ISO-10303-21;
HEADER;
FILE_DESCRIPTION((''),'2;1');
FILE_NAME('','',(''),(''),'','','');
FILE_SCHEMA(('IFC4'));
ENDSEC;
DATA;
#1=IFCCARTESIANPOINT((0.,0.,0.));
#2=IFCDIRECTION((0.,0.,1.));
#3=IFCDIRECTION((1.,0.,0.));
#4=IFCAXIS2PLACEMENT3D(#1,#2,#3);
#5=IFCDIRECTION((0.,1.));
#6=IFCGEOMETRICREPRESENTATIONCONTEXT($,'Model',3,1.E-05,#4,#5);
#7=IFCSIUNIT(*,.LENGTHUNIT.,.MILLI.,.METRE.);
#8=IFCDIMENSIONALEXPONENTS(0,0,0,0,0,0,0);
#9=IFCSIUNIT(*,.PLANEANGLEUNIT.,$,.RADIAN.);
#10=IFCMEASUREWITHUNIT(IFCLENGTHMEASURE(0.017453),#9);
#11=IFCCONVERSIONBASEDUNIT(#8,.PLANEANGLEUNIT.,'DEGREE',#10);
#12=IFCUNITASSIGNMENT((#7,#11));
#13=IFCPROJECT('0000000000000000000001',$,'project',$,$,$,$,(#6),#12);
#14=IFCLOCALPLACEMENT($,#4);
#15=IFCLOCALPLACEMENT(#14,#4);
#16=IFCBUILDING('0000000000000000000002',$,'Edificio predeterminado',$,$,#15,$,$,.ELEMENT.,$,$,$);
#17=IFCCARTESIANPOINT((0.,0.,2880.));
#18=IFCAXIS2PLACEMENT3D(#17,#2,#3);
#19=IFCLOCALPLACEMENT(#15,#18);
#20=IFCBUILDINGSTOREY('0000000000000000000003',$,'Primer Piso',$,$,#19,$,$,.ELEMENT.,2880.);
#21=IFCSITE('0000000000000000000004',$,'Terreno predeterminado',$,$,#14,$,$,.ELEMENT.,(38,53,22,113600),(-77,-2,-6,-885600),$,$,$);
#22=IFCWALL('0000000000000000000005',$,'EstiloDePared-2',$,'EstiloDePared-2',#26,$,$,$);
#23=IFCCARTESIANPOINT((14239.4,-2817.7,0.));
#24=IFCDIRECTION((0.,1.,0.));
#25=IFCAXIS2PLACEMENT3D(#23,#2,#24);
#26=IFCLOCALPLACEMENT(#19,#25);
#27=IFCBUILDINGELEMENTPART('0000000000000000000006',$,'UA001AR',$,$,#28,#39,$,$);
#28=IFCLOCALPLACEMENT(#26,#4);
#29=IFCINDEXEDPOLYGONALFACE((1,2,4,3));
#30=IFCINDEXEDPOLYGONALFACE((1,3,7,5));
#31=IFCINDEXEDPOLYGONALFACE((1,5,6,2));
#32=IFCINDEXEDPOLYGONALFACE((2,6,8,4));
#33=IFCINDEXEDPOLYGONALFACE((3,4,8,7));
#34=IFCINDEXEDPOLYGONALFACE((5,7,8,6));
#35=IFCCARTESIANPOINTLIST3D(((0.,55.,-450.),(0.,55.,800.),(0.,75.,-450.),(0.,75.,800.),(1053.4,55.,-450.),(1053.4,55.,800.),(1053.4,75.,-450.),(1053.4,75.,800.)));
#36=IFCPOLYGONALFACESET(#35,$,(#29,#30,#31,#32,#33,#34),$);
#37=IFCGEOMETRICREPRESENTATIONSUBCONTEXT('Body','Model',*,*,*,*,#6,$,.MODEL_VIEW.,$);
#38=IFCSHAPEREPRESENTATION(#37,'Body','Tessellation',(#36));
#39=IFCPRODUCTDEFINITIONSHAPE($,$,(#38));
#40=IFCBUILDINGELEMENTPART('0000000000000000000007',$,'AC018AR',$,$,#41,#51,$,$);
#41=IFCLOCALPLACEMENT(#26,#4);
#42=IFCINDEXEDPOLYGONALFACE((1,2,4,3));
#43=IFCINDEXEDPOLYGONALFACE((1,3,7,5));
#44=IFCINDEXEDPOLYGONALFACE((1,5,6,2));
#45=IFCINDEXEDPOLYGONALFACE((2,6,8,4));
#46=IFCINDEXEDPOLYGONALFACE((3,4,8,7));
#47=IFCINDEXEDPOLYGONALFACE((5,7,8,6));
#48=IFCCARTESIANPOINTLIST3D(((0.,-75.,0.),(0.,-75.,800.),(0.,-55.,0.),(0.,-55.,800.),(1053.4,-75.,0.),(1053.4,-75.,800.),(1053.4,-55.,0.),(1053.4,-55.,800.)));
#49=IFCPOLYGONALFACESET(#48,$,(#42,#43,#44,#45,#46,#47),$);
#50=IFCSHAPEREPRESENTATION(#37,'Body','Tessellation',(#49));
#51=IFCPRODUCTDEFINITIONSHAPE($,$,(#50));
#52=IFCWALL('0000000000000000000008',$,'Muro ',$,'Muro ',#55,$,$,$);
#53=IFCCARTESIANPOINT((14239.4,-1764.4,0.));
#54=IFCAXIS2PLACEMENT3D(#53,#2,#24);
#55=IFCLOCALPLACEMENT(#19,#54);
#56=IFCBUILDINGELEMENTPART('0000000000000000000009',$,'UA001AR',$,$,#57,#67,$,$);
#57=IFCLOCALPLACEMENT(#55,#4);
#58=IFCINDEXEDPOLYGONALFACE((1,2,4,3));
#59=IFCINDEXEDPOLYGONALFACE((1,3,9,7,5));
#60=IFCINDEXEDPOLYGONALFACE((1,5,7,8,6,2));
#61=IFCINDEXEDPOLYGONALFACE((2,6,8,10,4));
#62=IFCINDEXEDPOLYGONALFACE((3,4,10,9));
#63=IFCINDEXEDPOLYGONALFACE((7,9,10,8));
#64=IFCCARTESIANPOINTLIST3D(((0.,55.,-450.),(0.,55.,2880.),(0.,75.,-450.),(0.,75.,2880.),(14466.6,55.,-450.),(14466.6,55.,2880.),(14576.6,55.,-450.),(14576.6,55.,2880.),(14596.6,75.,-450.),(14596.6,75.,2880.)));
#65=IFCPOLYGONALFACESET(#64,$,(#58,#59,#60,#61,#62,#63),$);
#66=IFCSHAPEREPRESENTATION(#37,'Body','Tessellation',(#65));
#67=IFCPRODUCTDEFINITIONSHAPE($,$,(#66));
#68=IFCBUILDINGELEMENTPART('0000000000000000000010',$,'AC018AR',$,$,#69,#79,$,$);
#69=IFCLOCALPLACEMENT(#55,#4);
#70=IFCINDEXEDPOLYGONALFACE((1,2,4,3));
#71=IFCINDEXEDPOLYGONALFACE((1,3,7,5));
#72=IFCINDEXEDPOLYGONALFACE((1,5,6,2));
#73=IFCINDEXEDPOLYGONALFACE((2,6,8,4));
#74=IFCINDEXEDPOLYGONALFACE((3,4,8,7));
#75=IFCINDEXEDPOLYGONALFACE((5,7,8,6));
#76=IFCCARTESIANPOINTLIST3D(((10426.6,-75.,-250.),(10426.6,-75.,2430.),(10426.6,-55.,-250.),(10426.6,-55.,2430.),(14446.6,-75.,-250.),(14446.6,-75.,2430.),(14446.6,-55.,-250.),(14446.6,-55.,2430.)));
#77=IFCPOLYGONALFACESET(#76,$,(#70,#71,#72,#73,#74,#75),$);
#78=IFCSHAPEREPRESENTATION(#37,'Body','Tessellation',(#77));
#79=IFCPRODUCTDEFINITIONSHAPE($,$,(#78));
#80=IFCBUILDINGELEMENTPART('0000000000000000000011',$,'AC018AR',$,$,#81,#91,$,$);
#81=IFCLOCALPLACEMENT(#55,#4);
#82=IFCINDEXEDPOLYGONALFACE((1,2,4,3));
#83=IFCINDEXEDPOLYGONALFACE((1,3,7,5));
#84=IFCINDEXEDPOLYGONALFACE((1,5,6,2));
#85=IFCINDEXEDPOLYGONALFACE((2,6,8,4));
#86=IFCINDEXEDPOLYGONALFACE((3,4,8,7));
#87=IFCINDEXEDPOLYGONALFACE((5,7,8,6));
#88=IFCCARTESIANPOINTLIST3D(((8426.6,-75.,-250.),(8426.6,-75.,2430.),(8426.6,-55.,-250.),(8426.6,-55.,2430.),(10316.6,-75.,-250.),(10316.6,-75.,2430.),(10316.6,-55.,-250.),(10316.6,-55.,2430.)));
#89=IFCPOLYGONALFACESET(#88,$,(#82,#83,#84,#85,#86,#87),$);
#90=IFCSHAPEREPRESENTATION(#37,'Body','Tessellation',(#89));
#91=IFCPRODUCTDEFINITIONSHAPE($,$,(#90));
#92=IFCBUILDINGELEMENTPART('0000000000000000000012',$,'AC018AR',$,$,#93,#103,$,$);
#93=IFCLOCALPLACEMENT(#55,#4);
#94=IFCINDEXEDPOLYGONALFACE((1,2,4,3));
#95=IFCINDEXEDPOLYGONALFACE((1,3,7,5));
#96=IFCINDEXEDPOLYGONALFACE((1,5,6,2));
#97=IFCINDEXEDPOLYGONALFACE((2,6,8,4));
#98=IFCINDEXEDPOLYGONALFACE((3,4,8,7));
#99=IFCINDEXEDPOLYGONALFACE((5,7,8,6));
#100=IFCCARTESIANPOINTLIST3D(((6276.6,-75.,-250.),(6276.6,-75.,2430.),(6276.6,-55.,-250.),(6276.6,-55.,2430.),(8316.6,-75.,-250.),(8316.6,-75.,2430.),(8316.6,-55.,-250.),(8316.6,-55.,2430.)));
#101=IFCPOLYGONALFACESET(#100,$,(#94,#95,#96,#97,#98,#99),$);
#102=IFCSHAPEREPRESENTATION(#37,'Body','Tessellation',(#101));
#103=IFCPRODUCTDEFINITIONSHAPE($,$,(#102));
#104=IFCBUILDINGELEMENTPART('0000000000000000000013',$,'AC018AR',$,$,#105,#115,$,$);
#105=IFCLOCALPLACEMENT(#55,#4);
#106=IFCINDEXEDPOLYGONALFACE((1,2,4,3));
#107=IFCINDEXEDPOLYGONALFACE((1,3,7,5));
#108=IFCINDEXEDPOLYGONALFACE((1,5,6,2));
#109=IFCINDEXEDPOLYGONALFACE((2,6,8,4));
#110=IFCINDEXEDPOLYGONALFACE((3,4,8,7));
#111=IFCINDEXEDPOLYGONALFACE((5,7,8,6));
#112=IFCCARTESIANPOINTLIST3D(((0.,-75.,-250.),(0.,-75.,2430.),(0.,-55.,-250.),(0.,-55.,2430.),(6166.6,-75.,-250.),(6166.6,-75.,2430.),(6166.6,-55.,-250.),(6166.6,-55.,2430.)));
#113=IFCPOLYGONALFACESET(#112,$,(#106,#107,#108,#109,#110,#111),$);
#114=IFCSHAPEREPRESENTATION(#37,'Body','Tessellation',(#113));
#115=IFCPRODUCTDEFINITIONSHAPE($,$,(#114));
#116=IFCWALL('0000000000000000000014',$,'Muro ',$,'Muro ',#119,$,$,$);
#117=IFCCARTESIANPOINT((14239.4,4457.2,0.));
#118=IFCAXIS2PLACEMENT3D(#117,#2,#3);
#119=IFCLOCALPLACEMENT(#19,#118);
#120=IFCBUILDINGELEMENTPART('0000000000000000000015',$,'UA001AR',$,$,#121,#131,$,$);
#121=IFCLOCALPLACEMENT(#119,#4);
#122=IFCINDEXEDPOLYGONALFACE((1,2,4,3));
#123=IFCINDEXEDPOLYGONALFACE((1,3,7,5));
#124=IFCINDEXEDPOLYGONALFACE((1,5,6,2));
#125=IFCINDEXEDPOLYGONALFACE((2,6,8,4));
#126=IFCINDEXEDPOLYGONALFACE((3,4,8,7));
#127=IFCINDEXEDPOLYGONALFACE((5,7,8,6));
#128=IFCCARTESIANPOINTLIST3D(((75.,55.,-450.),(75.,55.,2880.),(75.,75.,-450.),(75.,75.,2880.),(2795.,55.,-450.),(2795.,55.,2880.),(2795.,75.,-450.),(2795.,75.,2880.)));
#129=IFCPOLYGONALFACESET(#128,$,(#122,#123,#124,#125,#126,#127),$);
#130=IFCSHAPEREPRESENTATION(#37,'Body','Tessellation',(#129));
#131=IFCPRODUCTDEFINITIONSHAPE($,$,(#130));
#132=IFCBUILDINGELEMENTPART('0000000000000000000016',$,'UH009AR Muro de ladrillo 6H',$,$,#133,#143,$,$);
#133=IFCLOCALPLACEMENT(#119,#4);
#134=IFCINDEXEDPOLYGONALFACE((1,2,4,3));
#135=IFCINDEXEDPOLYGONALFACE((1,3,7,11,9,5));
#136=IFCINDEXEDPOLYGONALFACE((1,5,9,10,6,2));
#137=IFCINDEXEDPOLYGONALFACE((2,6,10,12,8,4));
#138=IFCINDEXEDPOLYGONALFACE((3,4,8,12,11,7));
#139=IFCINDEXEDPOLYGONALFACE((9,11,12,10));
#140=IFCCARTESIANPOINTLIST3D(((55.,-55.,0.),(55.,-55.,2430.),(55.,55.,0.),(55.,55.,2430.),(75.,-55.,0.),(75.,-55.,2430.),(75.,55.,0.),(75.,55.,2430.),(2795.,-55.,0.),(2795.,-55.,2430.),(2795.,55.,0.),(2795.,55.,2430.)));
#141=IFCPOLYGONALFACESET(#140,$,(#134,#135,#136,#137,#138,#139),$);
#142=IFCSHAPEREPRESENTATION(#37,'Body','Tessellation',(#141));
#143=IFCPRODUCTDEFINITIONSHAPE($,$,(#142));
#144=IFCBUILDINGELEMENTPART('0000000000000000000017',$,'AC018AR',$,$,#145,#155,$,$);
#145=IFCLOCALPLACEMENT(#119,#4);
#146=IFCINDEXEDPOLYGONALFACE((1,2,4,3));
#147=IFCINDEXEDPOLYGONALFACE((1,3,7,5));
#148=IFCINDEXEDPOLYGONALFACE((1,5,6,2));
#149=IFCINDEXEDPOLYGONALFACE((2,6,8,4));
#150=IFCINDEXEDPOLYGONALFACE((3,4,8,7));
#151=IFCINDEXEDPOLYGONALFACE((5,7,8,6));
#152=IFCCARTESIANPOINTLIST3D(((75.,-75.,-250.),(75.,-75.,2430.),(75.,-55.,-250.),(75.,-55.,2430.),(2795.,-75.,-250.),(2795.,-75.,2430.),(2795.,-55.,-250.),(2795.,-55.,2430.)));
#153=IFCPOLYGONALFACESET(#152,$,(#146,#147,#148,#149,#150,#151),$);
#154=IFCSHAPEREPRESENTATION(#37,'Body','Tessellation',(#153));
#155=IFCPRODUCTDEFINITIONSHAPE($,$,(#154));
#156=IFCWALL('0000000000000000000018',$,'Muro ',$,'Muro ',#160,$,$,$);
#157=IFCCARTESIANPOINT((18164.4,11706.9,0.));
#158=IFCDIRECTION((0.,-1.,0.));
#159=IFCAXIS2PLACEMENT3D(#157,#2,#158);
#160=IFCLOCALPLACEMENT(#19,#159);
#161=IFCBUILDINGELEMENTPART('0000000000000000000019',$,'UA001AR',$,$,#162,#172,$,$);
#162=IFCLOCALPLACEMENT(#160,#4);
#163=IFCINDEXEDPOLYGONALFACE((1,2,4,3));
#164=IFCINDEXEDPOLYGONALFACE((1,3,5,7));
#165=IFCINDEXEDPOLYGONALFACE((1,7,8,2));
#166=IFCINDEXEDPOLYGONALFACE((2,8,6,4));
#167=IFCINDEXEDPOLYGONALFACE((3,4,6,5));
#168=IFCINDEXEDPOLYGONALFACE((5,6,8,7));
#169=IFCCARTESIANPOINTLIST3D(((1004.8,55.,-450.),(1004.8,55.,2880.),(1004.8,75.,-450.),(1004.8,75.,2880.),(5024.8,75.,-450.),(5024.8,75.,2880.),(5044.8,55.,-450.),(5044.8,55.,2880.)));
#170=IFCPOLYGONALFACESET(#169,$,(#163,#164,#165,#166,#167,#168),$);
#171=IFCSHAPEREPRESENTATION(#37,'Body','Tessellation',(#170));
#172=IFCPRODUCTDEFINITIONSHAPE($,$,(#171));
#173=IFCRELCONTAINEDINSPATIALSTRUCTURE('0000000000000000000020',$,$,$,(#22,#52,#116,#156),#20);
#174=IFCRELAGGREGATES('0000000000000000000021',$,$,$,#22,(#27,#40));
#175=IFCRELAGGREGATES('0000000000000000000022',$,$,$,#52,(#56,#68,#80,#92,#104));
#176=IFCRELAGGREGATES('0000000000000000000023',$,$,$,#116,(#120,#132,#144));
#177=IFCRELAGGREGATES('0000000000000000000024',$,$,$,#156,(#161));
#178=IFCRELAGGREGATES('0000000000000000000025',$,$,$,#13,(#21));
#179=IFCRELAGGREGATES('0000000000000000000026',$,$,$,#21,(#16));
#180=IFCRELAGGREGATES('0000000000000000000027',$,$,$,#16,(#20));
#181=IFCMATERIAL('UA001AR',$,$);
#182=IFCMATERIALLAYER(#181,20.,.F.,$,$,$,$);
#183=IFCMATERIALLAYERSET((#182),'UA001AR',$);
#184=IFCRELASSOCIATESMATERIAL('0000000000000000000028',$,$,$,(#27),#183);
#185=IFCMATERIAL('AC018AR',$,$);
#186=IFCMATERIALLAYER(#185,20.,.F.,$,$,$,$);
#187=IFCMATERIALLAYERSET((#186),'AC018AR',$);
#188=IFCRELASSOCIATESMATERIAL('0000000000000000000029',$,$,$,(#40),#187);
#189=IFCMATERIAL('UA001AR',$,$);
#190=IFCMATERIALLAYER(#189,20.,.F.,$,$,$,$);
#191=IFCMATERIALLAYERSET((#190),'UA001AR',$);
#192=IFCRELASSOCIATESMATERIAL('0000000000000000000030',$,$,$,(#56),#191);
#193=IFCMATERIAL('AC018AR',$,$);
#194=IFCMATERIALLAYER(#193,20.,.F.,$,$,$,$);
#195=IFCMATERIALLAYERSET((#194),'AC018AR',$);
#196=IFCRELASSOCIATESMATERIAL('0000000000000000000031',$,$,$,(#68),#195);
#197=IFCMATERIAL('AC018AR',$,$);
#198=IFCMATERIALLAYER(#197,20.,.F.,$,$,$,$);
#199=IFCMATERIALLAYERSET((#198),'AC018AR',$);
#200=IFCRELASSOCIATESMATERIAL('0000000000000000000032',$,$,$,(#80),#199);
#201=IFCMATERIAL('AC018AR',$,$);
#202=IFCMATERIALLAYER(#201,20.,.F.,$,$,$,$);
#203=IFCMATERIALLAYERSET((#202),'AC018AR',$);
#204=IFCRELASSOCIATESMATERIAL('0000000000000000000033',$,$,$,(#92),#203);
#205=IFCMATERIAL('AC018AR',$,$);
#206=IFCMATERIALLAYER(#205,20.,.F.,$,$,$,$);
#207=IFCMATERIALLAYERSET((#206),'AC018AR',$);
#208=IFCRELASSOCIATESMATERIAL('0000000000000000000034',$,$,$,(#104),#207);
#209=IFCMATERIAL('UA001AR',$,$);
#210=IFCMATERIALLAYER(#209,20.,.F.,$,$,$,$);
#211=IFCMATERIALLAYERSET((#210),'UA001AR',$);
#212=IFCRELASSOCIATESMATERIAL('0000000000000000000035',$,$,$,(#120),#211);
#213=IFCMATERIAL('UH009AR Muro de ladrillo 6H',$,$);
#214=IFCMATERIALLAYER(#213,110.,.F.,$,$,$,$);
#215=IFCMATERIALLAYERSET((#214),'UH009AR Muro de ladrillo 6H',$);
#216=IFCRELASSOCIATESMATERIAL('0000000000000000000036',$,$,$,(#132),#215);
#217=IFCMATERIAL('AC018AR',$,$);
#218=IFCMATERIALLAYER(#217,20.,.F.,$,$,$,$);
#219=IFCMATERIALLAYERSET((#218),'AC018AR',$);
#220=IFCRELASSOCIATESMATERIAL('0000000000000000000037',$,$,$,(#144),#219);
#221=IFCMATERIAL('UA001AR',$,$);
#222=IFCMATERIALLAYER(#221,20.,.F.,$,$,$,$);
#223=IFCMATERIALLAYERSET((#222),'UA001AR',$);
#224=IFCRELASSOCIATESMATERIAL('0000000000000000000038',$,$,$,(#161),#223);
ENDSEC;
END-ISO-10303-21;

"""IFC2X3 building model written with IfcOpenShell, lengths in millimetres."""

from ifc_helpers import new_model, entity, si_unit, converted_unit, direction, frame, origin_with_axes, place, context, subcontext, project, spatial, polyline, outline, extrude, material, layer, layer_set, layer_usage, element, aggregate, save


model = new_model("IFC2X3")

# Units and contexts
model_context = context("Model", 3, precision=1e-05, world=origin_with_axes(), true_north=direction((0.0, 1.0)))
body_context = subcontext(model_context, "Body", "Model", "MODEL_VIEW")
ifc_project = project(units=[si_unit("LENGTHUNIT", "METRE", prefix="MILLI"), converted_unit("PLANEANGLEUNIT", "DEGREE", entity("IfcLengthMeasure", 0.017453), si_unit("PLANEANGLEUNIT", "RADIAN"), dimensions=[0, 0, 0, 0, 0, 0, 0])], contexts=[model_context])

# Site, building, storey
site_placement = place(None, origin_with_axes())
site = spatial("IfcSite", under=ifc_project, at=site_placement, Name="Terreno predeterminado", CompositionType="ELEMENT", RefLatitude=(38, 53, 22, 113600), RefLongitude=(-77, -2, -6, -885600))
building_placement = place(site_placement, origin_with_axes())
building = spatial("IfcBuilding", under=site, at=building_placement, Name="Edificio predeterminado", CompositionType="ELEMENT")
storey_placement = place(building_placement, frame((0.0, 0.0, 2880.0), z_axis=(0.0, 0.0, 1.0), x_axis=(1.0, 0.0, 0.0)))
storey = spatial("IfcBuildingStorey", under=building, at=storey_placement, Name="Primer Piso", CompositionType="ELEMENT", Elevation=2880.0)

# Walls, building element parts
wall_1_placement = place(storey_placement, frame((14239.4, -2817.7, 0.0), z_axis=(0.0, 0.0, 1.0), x_axis=(0.0, 1.0, 0.0)))
wall_1 = element("IfcWall", 1, at=wall_1_placement, inside=storey, Name="EstiloDePared-2", ObjectType="EstiloDePared-2")
ifc_material_1 = material(Name="UA001AR")
ifc_layer_1 = layer(ifc_material_1, 20.0, ventilated=False)
ifc_layer_set_1 = layer_set([ifc_layer_1], Name="UA001AR")
ifc_layer_usage_1 = layer_usage(ifc_layer_set_1, "AXIS2", "NEGATIVE", -75.0)
building_element_part_1_placement = place(wall_1_placement, origin_with_axes())
building_element_part_1 = element("IfcBuildingElementPart", 2, at=building_element_part_1_placement, material=ifc_layer_usage_1, Name="UA001AR", context=body_context, shape_type="SweptSolid", body=[
    extrude(outline(polyline([(1053.4, 75.0), (1053.4, 55.0), (0.0, 55.0), (0.0, 75.0), (1053.4, 75.0)])), frame((0.0, 0.0, -450.0), z_axis=(0.0, 0.0, 1.0), x_axis=(1.0, 0.0, 0.0)), (0.0, 0.0, 1.0), 1250.0),
])
ifc_material_2 = material(Name="AC018AR")
ifc_layer_2 = layer(ifc_material_2, 20.0, ventilated=False)
ifc_layer_set_2 = layer_set([ifc_layer_2], Name="AC018AR")
ifc_layer_usage_2 = layer_usage(ifc_layer_set_2, "AXIS2", "NEGATIVE", 55.0)
building_element_part_2_placement = place(wall_1_placement, origin_with_axes())
building_element_part_2 = element("IfcBuildingElementPart", 3, at=building_element_part_2_placement, material=ifc_layer_usage_2, Name="AC018AR", context=body_context, shape_type="SweptSolid", body=[
    extrude(outline(polyline([(1053.4, -55.0), (1053.4, -75.0), (0.0, -75.0), (0.0, -55.0), (1053.4, -55.0)])), origin_with_axes(), (0.0, 0.0, 1.0), 800.0),
])
aggregate(wall_1, [building_element_part_1, building_element_part_2])
wall_2_placement = place(storey_placement, frame((14239.4, -1764.4, 0.0), z_axis=(0.0, 0.0, 1.0), x_axis=(0.0, 1.0, 0.0)))
wall_2 = element("IfcWall", 4, at=wall_2_placement, inside=storey, Name="Muro ", ObjectType="Muro ")
ifc_material_3 = material(Name="UA001AR")
ifc_layer_3 = layer(ifc_material_3, 20.0, ventilated=False)
ifc_layer_set_3 = layer_set([ifc_layer_3], Name="UA001AR")
ifc_layer_usage_3 = layer_usage(ifc_layer_set_3, "AXIS2", "NEGATIVE", -75.0)
building_element_part_3_placement = place(wall_2_placement, origin_with_axes())
building_element_part_3 = element("IfcBuildingElementPart", 5, at=building_element_part_3_placement, material=ifc_layer_usage_3, Name="UA001AR", context=body_context, shape_type="SweptSolid", body=[
    extrude(outline(polyline([(14596.6, 75.0), (14576.6, 55.0), (14466.6, 55.0), (0.0, 55.0), (0.0, 75.0), (14596.6, 75.0)])), frame((0.0, 0.0, -450.0), z_axis=(0.0, 0.0, 1.0), x_axis=(1.0, 0.0, 0.0)), (0.0, 0.0, 1.0), 3330.0),
])
ifc_material_4 = material(Name="AC018AR")
ifc_layer_4 = layer(ifc_material_4, 20.0, ventilated=False)
ifc_layer_set_4 = layer_set([ifc_layer_4], Name="AC018AR")
ifc_layer_usage_4 = layer_usage(ifc_layer_set_4, "AXIS2", "NEGATIVE", 55.0)
building_element_part_4_placement = place(wall_2_placement, origin_with_axes())
building_element_part_4 = element("IfcBuildingElementPart", 6, at=building_element_part_4_placement, material=ifc_layer_usage_4, Name="AC018AR", context=body_context, shape_type="SweptSolid", body=[
    extrude(outline(polyline([(14446.6, -55.0), (14446.6, -75.0), (10426.6, -75.0), (10426.6, -55.0), (14446.6, -55.0)])), frame((0.0, 0.0, -250.0), z_axis=(0.0, 0.0, 1.0), x_axis=(1.0, 0.0, 0.0)), (0.0, 0.0, 1.0), 2680.0),
])
ifc_material_5 = material(Name="AC018AR")
ifc_layer_5 = layer(ifc_material_5, 20.0, ventilated=False)
ifc_layer_set_5 = layer_set([ifc_layer_5], Name="AC018AR")
ifc_layer_usage_5 = layer_usage(ifc_layer_set_5, "AXIS2", "NEGATIVE", 55.0)
building_element_part_5_placement = place(wall_2_placement, origin_with_axes())
building_element_part_5 = element("IfcBuildingElementPart", 7, at=building_element_part_5_placement, material=ifc_layer_usage_5, Name="AC018AR", context=body_context, shape_type="SweptSolid", body=[
    extrude(outline(polyline([(10316.6, -55.0), (10316.6, -75.0), (8426.6, -75.0), (8426.6, -55.0), (10316.6, -55.0)])), frame((0.0, 0.0, -250.0), z_axis=(0.0, 0.0, 1.0), x_axis=(1.0, 0.0, 0.0)), (0.0, 0.0, 1.0), 2680.0),
])
ifc_material_6 = material(Name="AC018AR")
ifc_layer_6 = layer(ifc_material_6, 20.0, ventilated=False)
ifc_layer_set_6 = layer_set([ifc_layer_6], Name="AC018AR")
ifc_layer_usage_6 = layer_usage(ifc_layer_set_6, "AXIS2", "NEGATIVE", 55.0)
building_element_part_6_placement = place(wall_2_placement, origin_with_axes())
building_element_part_6 = element("IfcBuildingElementPart", 8, at=building_element_part_6_placement, material=ifc_layer_usage_6, Name="AC018AR", context=body_context, shape_type="SweptSolid", body=[
    extrude(outline(polyline([(8316.6, -55.0), (8316.6, -75.0), (6276.6, -75.0), (6276.6, -55.0), (8316.6, -55.0)])), frame((0.0, 0.0, -250.0), z_axis=(0.0, 0.0, 1.0), x_axis=(1.0, 0.0, 0.0)), (0.0, 0.0, 1.0), 2680.0),
])
ifc_material_7 = material(Name="AC018AR")
ifc_layer_7 = layer(ifc_material_7, 20.0, ventilated=False)
ifc_layer_set_7 = layer_set([ifc_layer_7], Name="AC018AR")
ifc_layer_usage_7 = layer_usage(ifc_layer_set_7, "AXIS2", "NEGATIVE", 55.0)
building_element_part_7_placement = place(wall_2_placement, origin_with_axes())
building_element_part_7 = element("IfcBuildingElementPart", 9, at=building_element_part_7_placement, material=ifc_layer_usage_7, Name="AC018AR", context=body_context, shape_type="SweptSolid", body=[
    extrude(outline(polyline([(6166.6, -55.0), (6166.6, -75.0), (0.0, -75.0), (0.0, -55.0), (6166.6, -55.0)])), frame((0.0, 0.0, -250.0), z_axis=(0.0, 0.0, 1.0), x_axis=(1.0, 0.0, 0.0)), (0.0, 0.0, 1.0), 2680.0),
])
aggregate(wall_2, [building_element_part_3, building_element_part_4, building_element_part_5, building_element_part_6, building_element_part_7])
wall_3_placement = place(storey_placement, frame((14239.4, 4457.2, 0.0), z_axis=(0.0, 0.0, 1.0), x_axis=(1.0, 0.0, 0.0)))
wall_3 = element("IfcWall", 10, at=wall_3_placement, inside=storey, Name="Muro ", ObjectType="Muro ")
ifc_material_8 = material(Name="UA001AR")
ifc_layer_8 = layer(ifc_material_8, 20.0, ventilated=False)
ifc_layer_set_8 = layer_set([ifc_layer_8], Name="UA001AR")
ifc_layer_usage_8 = layer_usage(ifc_layer_set_8, "AXIS2", "NEGATIVE", -75.0)
building_element_part_8_placement = place(wall_3_placement, origin_with_axes())
building_element_part_8 = element("IfcBuildingElementPart", 11, at=building_element_part_8_placement, material=ifc_layer_usage_8, Name="UA001AR", context=body_context, shape_type="SweptSolid", body=[
    extrude(outline(polyline([(2795.0, 75.0), (2795.0, 55.0), (75.0, 55.0), (75.0, 75.0), (2795.0, 75.0)])), frame((0.0, 0.0, -450.0), z_axis=(0.0, 0.0, 1.0), x_axis=(1.0, 0.0, 0.0)), (0.0, 0.0, 1.0), 3330.0),
])
ifc_material_9 = material(Name="UH009AR Muro de ladrillo 6H")
ifc_layer_9 = layer(ifc_material_9, 110.0, ventilated=False)
ifc_layer_set_9 = layer_set([ifc_layer_9], Name="UH009AR Muro de ladrillo 6H")
ifc_layer_usage_9 = layer_usage(ifc_layer_set_9, "AXIS2", "NEGATIVE", -55.0)
building_element_part_9_placement = place(wall_3_placement, origin_with_axes())
building_element_part_9 = element("IfcBuildingElementPart", 12, at=building_element_part_9_placement, material=ifc_layer_usage_9, Name="UH009AR Muro de ladrillo 6H", context=body_context, shape_type="SweptSolid", body=[
    extrude(outline(polyline([(2795.0, 55.0), (2795.0, -55.0), (75.0, -55.0), (55.0, -55.0), (55.0, 55.0), (75.0, 55.0), (2795.0, 55.0)])), origin_with_axes(), (0.0, 0.0, 1.0), 2430.0),
])
ifc_material_10 = material(Name="AC018AR")
ifc_layer_10 = layer(ifc_material_10, 20.0, ventilated=False)
ifc_layer_set_10 = layer_set([ifc_layer_10], Name="AC018AR")
ifc_layer_usage_10 = layer_usage(ifc_layer_set_10, "AXIS2", "NEGATIVE", 55.0)
building_element_part_10_placement = place(wall_3_placement, origin_with_axes())
building_element_part_10 = element("IfcBuildingElementPart", 13, at=building_element_part_10_placement, material=ifc_layer_usage_10, Name="AC018AR", context=body_context, shape_type="SweptSolid", body=[
    extrude(outline(polyline([(75.0, -55.0), (2795.0, -55.0), (2795.0, -75.0), (75.0, -75.0), (75.0, -55.0)])), frame((0.0, 0.0, -250.0), z_axis=(0.0, 0.0, 1.0), x_axis=(1.0, 0.0, 0.0)), (0.0, 0.0, 1.0), 2680.0),
])
aggregate(wall_3, [building_element_part_8, building_element_part_9, building_element_part_10])
wall_4_placement = place(storey_placement, frame((18164.4, 11706.9, 0.0), z_axis=(0.0, 0.0, 1.0), x_axis=(0.0, -1.0, 0.0)))
wall_4 = element("IfcWall", 14, at=wall_4_placement, inside=storey, Name="Muro ", ObjectType="Muro ")
ifc_material_11 = material(Name="UA001AR")
ifc_layer_11 = layer(ifc_material_11, 20.0, ventilated=False)
ifc_layer_set_11 = layer_set([ifc_layer_11], Name="UA001AR")
ifc_layer_usage_11 = layer_usage(ifc_layer_set_11, "AXIS2", "NEGATIVE", -75.0)
building_element_part_11_placement = place(wall_4_placement, origin_with_axes())
building_element_part_11 = element("IfcBuildingElementPart", 15, at=building_element_part_11_placement, material=ifc_layer_usage_11, Name="UA001AR", context=body_context, shape_type="SweptSolid", body=[
    extrude(outline(polyline([(5024.8, 75.0), (5044.8, 55.0), (1004.8, 55.0), (1004.8, 75.0), (5024.8, 75.0)])), frame((0.0, 0.0, -450.0), z_axis=(0.0, 0.0, 1.0), x_axis=(1.0, 0.0, 0.0)), (0.0, 0.0, 1.0), 3330.0),
])
aggregate(wall_4, [building_element_part_11])

save(model, "model.ifc")
